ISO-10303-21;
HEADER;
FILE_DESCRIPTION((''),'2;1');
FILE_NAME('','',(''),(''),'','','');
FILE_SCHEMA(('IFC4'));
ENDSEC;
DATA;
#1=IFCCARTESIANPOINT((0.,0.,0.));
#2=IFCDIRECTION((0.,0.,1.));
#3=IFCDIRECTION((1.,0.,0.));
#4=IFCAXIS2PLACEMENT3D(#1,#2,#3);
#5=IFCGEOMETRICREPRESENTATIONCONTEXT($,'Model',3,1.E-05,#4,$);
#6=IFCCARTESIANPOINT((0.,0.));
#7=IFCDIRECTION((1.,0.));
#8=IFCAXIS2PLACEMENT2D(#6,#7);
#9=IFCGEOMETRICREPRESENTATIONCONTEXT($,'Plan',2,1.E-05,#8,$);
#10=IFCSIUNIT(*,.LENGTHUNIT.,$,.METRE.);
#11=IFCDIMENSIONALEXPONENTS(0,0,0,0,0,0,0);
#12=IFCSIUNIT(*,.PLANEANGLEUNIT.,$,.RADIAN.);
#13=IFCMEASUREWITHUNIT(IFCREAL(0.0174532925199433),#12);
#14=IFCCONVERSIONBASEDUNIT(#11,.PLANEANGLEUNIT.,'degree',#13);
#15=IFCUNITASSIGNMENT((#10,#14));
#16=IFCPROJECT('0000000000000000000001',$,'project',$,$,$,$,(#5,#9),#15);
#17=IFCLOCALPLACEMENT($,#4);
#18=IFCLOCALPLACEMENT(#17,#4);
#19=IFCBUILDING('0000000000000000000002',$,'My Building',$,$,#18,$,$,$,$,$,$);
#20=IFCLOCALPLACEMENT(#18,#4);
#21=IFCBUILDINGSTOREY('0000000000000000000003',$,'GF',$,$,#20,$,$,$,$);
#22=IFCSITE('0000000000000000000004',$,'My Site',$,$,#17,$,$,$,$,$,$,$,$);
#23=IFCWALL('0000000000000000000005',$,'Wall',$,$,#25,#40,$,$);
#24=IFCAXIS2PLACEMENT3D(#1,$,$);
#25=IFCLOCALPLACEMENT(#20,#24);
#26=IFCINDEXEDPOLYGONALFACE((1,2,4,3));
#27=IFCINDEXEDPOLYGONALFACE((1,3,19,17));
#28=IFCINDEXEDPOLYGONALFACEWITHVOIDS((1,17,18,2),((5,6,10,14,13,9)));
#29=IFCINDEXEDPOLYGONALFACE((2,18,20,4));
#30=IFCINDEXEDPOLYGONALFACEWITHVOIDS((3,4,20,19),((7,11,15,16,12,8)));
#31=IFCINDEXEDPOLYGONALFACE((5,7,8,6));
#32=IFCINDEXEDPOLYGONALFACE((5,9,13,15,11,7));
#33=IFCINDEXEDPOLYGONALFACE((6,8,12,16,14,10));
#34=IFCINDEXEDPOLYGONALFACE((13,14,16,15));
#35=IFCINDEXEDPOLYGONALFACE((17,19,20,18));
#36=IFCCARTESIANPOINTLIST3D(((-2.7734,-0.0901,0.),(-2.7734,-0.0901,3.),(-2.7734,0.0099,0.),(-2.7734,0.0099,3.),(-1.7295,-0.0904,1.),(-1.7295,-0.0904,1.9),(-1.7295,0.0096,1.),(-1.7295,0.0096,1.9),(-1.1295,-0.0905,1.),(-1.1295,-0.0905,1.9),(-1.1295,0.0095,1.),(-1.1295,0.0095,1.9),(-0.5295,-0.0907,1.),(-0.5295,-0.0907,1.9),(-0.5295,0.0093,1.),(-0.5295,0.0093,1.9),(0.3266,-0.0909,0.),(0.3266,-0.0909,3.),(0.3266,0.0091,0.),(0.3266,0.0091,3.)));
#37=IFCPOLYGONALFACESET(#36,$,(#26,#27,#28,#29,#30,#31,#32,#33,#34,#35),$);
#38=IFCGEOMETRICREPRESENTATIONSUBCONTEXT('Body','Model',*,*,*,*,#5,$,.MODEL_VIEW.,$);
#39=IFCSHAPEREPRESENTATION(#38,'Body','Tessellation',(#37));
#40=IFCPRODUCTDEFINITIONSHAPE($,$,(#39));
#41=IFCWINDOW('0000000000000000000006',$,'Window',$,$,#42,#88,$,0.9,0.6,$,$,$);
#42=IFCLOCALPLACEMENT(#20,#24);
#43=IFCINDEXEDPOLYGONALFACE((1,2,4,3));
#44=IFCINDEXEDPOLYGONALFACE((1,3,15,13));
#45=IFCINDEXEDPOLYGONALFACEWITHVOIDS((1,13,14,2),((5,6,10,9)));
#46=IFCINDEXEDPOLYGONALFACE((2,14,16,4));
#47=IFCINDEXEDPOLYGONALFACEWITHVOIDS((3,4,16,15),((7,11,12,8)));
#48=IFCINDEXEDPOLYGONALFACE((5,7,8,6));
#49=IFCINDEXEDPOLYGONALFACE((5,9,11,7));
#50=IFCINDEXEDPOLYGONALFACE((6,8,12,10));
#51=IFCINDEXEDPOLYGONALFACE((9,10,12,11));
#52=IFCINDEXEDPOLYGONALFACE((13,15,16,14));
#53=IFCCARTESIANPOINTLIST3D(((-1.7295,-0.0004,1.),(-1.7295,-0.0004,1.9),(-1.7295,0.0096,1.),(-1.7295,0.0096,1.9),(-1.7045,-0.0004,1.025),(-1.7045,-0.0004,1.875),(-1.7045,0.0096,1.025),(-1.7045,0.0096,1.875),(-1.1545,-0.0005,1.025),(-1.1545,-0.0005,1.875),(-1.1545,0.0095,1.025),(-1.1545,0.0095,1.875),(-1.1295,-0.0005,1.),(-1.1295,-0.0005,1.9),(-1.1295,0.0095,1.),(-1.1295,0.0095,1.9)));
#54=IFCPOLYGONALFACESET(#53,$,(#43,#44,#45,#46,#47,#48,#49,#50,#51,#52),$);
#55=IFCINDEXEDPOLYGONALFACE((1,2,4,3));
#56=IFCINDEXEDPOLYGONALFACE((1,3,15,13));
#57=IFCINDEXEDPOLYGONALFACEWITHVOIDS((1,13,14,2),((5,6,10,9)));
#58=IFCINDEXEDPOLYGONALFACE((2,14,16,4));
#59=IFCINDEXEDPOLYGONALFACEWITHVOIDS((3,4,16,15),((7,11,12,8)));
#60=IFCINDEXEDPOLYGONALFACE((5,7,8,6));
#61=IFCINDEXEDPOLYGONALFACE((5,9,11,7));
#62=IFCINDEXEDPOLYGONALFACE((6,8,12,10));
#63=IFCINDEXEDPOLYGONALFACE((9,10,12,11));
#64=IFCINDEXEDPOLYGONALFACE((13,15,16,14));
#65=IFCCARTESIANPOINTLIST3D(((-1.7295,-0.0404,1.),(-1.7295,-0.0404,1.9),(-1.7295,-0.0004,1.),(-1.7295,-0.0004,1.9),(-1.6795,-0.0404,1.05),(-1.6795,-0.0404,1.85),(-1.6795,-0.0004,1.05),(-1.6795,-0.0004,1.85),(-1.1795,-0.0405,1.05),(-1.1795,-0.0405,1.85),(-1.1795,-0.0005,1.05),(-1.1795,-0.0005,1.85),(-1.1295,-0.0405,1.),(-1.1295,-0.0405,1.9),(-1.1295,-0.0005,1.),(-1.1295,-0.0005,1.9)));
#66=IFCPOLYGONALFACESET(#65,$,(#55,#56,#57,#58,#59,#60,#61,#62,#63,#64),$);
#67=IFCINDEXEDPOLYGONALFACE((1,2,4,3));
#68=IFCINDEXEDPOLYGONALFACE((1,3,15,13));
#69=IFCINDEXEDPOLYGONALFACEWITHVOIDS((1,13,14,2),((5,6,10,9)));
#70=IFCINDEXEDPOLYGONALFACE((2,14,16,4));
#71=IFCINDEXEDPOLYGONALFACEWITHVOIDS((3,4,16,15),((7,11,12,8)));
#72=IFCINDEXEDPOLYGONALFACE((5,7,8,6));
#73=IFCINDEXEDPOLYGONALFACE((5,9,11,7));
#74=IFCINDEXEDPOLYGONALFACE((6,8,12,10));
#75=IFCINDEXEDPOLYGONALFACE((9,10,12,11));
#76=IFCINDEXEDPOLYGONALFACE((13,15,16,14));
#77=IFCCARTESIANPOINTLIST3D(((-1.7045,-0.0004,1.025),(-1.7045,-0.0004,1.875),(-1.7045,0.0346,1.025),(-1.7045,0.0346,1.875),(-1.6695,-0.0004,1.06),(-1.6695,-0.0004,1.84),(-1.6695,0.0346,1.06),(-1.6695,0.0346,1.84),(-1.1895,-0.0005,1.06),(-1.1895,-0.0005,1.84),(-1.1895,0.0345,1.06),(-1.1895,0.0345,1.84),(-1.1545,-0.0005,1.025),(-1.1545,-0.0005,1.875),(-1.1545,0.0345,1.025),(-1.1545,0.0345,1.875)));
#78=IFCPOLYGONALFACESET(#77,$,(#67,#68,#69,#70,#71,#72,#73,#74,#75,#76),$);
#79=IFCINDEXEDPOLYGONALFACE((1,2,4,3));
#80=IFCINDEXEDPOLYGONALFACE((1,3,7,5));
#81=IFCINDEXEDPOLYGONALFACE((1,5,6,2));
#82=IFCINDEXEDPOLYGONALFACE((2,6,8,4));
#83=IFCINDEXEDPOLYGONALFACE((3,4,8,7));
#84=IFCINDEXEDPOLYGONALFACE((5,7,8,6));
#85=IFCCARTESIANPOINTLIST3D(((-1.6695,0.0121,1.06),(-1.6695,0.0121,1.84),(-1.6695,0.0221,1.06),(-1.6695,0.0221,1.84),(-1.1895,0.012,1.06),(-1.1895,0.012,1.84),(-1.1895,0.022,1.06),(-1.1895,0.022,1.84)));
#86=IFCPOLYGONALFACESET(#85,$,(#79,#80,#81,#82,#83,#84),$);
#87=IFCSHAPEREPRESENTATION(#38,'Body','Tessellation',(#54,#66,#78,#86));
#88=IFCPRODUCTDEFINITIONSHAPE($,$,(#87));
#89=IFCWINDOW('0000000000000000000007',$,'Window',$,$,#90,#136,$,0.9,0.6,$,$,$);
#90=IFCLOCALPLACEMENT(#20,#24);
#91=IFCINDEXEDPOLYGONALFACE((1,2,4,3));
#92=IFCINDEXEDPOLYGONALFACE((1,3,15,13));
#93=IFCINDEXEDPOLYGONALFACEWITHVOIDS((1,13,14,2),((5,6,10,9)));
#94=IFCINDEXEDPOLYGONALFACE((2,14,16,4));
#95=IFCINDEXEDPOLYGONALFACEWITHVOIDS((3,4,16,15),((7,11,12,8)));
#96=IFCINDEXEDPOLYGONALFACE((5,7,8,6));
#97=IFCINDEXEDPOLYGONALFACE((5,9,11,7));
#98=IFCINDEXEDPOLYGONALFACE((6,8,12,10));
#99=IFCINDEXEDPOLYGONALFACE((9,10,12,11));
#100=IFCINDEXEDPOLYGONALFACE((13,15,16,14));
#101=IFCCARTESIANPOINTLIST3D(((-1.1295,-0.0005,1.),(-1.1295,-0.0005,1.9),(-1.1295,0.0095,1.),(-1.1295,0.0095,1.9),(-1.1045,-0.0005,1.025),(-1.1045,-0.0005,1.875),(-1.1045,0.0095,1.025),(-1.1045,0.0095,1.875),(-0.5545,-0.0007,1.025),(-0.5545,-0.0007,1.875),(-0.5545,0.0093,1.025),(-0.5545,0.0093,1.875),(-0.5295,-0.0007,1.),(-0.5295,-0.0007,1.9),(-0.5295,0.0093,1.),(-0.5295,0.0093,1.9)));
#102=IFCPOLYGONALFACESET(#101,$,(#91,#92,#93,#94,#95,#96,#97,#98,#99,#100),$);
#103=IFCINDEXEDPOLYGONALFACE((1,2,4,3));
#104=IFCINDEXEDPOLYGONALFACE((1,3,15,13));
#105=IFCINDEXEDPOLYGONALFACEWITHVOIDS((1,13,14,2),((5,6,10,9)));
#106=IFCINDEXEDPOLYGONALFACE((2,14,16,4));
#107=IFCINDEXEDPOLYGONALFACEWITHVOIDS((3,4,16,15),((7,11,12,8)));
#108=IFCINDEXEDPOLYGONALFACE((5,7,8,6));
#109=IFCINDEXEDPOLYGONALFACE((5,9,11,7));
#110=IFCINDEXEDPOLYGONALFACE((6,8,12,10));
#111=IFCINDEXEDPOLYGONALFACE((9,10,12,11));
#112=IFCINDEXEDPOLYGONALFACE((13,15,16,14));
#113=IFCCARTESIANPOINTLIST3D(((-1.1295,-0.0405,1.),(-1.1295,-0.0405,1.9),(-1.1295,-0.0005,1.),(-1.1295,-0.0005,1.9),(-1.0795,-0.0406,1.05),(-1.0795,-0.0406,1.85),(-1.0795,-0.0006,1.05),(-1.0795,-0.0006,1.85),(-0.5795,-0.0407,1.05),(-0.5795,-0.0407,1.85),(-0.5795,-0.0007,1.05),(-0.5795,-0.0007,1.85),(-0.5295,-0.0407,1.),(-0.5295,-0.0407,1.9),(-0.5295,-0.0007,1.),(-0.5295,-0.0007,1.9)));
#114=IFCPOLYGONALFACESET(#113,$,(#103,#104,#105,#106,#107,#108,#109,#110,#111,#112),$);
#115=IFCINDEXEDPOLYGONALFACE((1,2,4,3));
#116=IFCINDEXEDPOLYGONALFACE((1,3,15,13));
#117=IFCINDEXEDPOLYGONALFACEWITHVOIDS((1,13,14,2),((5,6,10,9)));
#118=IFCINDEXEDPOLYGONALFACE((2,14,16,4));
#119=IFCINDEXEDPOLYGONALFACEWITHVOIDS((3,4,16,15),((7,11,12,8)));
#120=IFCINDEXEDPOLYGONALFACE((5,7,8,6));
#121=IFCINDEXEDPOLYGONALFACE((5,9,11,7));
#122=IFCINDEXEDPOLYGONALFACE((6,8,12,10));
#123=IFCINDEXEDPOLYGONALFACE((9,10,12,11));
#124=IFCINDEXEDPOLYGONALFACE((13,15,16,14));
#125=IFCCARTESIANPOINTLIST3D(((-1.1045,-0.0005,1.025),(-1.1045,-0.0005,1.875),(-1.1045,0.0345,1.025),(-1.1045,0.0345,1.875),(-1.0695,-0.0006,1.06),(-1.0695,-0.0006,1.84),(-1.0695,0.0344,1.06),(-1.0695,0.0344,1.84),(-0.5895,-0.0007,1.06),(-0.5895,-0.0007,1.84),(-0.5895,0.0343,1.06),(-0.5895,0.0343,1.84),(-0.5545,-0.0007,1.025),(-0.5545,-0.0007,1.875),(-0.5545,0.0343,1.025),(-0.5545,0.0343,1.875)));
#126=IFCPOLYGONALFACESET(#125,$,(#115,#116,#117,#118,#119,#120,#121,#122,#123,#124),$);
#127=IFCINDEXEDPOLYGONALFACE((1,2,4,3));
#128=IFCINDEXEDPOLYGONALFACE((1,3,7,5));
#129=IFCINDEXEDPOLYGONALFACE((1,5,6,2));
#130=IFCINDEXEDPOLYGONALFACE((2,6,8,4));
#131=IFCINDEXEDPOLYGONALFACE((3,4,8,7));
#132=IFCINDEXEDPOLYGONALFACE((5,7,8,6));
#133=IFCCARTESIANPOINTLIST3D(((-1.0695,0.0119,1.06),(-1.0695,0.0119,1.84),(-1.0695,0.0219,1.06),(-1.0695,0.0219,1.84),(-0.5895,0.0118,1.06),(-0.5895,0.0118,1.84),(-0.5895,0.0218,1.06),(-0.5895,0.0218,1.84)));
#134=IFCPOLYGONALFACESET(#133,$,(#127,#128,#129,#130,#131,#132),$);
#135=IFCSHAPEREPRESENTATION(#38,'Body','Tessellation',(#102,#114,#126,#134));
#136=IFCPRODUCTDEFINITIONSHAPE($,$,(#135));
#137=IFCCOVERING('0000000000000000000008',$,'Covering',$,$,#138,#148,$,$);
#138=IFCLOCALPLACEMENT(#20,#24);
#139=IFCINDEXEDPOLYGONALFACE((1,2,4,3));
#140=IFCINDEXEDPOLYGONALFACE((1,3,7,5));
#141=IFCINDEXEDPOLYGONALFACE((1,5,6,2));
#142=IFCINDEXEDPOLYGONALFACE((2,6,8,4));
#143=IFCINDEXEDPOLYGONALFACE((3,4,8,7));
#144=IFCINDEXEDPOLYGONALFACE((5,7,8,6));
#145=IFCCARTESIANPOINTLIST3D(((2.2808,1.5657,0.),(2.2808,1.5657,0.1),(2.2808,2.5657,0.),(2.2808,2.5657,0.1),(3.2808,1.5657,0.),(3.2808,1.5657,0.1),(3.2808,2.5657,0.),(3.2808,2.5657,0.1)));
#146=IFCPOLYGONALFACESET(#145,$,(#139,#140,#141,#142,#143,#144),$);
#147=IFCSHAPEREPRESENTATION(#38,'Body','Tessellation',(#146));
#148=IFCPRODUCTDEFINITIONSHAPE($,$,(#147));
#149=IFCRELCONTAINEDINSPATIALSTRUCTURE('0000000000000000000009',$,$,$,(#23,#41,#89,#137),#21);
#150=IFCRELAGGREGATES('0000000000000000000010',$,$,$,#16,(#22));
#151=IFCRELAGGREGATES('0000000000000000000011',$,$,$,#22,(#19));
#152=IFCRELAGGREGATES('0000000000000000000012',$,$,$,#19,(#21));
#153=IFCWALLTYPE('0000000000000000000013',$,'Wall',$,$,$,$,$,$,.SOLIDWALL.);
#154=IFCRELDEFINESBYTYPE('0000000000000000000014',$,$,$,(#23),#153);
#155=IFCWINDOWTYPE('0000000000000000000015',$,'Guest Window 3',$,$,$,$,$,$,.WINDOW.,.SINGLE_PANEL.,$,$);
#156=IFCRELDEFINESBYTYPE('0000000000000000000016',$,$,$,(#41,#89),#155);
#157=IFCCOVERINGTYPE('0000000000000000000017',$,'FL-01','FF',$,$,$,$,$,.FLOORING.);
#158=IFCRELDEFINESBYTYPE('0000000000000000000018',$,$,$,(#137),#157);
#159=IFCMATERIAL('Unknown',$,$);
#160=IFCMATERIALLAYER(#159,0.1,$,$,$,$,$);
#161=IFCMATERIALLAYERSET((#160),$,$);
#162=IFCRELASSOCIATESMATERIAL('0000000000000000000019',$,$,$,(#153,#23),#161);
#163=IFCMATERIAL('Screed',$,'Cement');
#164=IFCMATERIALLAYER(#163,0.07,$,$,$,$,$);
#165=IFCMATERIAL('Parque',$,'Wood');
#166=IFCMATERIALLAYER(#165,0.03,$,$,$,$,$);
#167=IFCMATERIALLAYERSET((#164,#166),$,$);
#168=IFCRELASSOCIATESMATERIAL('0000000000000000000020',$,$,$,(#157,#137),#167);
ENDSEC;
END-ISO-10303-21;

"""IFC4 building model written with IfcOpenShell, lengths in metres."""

from ifc_helpers import new_model, entity, si_unit, converted_unit, frame, origin_with_axes, origin_2d_with_axis, place, context, subcontext, project, spatial, line, indexed_curve, outline, extrude, shape, source, transform, mapped, material, layer, layer_set, layer_usage, type_object, type_shapes, element, fill, save


model = new_model("IFC4")

# Units and contexts
model_context = context("Model", 3, precision=1e-05, world=origin_with_axes())
plan_context = context("Plan", 2, precision=1e-05, world=origin_2d_with_axis())
body_context_1 = subcontext(model_context, "Body", "Model", "MODEL_VIEW")
body_context_2 = subcontext(plan_context, "Body", "Plan", "PLAN_VIEW")
ifc_project = project(units=[si_unit("LENGTHUNIT", "METRE"), converted_unit("PLANEANGLEUNIT", "degree", entity("IfcReal", 0.0174532925199433), si_unit("PLANEANGLEUNIT", "RADIAN"), dimensions=[0, 0, 0, 0, 0, 0, 0])], contexts=[model_context, plan_context])

# Site, building, storey
site_placement = place(None, origin_with_axes())
site = spatial("IfcSite", under=ifc_project, at=site_placement, Name="My Site")
building_placement = place(site_placement, origin_with_axes())
building = spatial("IfcBuilding", under=site, at=building_placement, Name="My Building")
storey_placement = place(building_placement, origin_with_axes())
storey = spatial("IfcBuildingStorey", under=building, at=storey_placement, Name="GF")

# Shared definitions
ifc_material_1 = material(Name="Unknown")

# Shared definitions
ifc_layer_1 = layer(ifc_material_1, 0.1)
ifc_layer_set_1 = layer_set([ifc_layer_1])
wall_type = type_object("IfcWallType", Name="Wall", PredefinedType="SOLIDWALL", material=ifc_layer_set_1)

# Wall, openings, windows
ifc_layer_usage_1 = layer_usage(ifc_layer_set_1, "AXIS2", "POSITIVE", 0.0)
wall_1_placement = place(storey_placement, frame((-2.7734, -0.0901, 0.0), z_axis=(0.0, 0.0, 1.0), x_axis=(1.0, -0.000264, 0.0)))
wall_1 = element("IfcWall", 1, at=wall_1_placement, inside=storey, type_object=wall_type, material=ifc_layer_usage_1, Name="Wall", context=body_context_1, shape_type="SweptSolid", body=[
    extrude(outline(indexed_curve([(0.0, 0.0), (0.0, 0.1), (3.1, 0.1), (3.1, 0.0)], segments=[line(1, 2, 3, 4, 1)])), origin_with_axes(), (0.0, 0.0, 1.0), 3.0),
])
shared_shape_1 = source(origin_with_axes(), body_context_1, "Body", "SweptSolid", [
    extrude(outline(indexed_curve([(0.0, 0.0), (0.6, 0.0), (0.6, 0.9), (0.0, 0.9)], segments=[line(1, 2, 3, 4, 1)])), frame((0.0, -0.6, 0.0), z_axis=(0.0, -1.0, 0.0), x_axis=(1.0, 0.0, 0.0)), (0.0, 0.0, -1.0), 1.2),
])
opening_1_placement = place(wall_1_placement, frame((1.0439, 0.0, 1.0), z_axis=(0.0, 0.0, 1.0), x_axis=(1.0, 0.0, 0.0)))
opening_1 = element("IfcOpeningElement", 2, at=opening_1_placement, cuts=wall_1, PredefinedType="OPENING", context=body_context_1, shape_type="MappedRepresentation", body=[
    mapped(shared_shape_1, transform((0.0, 0.0, 0.0), x_axis=(1.0, 0.0, 0.0), y_axis=(0.0, 1.0, 0.0), z_axis=(0.0, 0.0, 1.0), scale=1.0)),
])
opening_2_placement = place(wall_1_placement, frame((1.6439, 0.0, 1.0), z_axis=(0.0, 0.0, 1.0), x_axis=(1.0, 0.0, 0.0)))
opening_2 = element("IfcOpeningElement", 3, at=opening_2_placement, cuts=wall_1, PredefinedType="OPENING", context=body_context_1, shape_type="MappedRepresentation", body=[
    mapped(shared_shape_1, transform((0.0, 0.0, 0.0), x_axis=(1.0, 0.0, 0.0), y_axis=(0.0, 1.0, 0.0), z_axis=(0.0, 0.0, 1.0), scale=1.0)),
])
window_type_1 = type_object("IfcWindowType", Name="Guest Window 3", PartitioningType="SINGLE_PANEL", PredefinedType="WINDOW")
shared_shape_2 = source(origin_with_axes(), body_context_1, "Body", "SweptSolid", [
    extrude(outline(indexed_curve([(0.0, 0.0), (0.6, 0.0), (0.6, 0.9), (0.0, 0.9)], segments=[line(1, 2, 3, 4, 1)]), holes=[indexed_curve([(0.025, 0.025), (0.575, 0.025), (0.575, 0.875), (0.025, 0.875)], segments=[line(1, 2, 3, 4, 1)])]), frame((0.0, 0.09, 0.0), z_axis=(0.0, -1.0, 0.0), x_axis=(1.0, 0.0, 0.0)), (0.0, 0.0, -1.0), 0.01),
    extrude(outline(indexed_curve([(0.0, 0.0), (0.6, 0.0), (0.6, 0.9), (0.0, 0.9)], segments=[line(1, 2, 3, 4, 1)]), holes=[indexed_curve([(0.05, 0.05), (0.55, 0.05), (0.55, 0.85), (0.05, 0.85)], segments=[line(1, 2, 3, 4, 1)])]), frame((0.0, 0.05, 0.0), z_axis=(0.0, -1.0, 0.0), x_axis=(1.0, 0.0, 0.0)), (0.0, 0.0, -1.0), 0.04),
    extrude(outline(indexed_curve([(0.0, 0.0), (0.55, 0.0), (0.55, 0.85), (0.0, 0.85)], segments=[line(1, 2, 3, 4, 1)]), holes=[indexed_curve([(0.035, 0.035), (0.515, 0.035), (0.515, 0.815), (0.035, 0.815)], segments=[line(1, 2, 3, 4, 1)])]), frame((0.025, 0.09, 0.025), z_axis=(0.0, -1.0, 0.0), x_axis=(1.0, 0.0, 0.0)), (0.0, 0.0, -1.0), 0.035),
    extrude(outline(indexed_curve([(0.035, 0.035), (0.515, 0.035), (0.515, 0.815), (0.035, 0.815)], segments=[line(1, 2, 3, 4, 1)])), frame((0.025, 0.1025, 0.025), z_axis=(0.0, -1.0, 0.0), x_axis=(1.0, 0.0, 0.0)), (0.0, 0.0, -1.0), 0.01),
])
shared_shape_3 = source(origin_with_axes(), body_context_2, "Body", "Curve2D", [
    entity("IfcIndexedPolyCurve", entity("IfcCartesianPointList2D", [[0.05, 0.05], [0.55, 0.05]])),
    entity("IfcIndexedPolyCurve", entity("IfcCartesianPointList2D", [[0.0, 0.1], [0.025, 0.1], [0.025, 0.09], [0.05, 0.09], [0.05, 0.05], [0.0, 0.05]]), [entity("IfcLineIndex", [1, 2, 3, 4, 5, 6, 1])]),
    entity("IfcIndexedPolyCurve", entity("IfcCartesianPointList2D", [[0.6, 0.1], [0.575, 0.1], [0.575, 0.09], [0.55, 0.09], [0.55, 0.05], [0.6, 0.05]]), [entity("IfcLineIndex", [1, 2, 3, 4, 5, 6, 1])]),
    entity("IfcIndexedPolyCurve", entity("IfcCartesianPointList2D", [[0.025, 0.09], [0.06, 0.09], [0.06, 0.125], [0.025, 0.125]]), [entity("IfcLineIndex", [1, 2, 3, 4, 1])]),
    entity("IfcIndexedPolyCurve", entity("IfcCartesianPointList2D", [[0.575, 0.09], [0.54, 0.09], [0.54, 0.125], [0.575, 0.125]]), [entity("IfcLineIndex", [1, 2, 3, 4, 1])]),
    entity("IfcIndexedPolyCurve", entity("IfcCartesianPointList2D", [[0.06, 0.09], [0.54, 0.09]])),
    entity("IfcIndexedPolyCurve", entity("IfcCartesianPointList2D", [[0.06, 0.125], [0.54, 0.125]])),
    entity("IfcIndexedPolyCurve", entity("IfcCartesianPointList2D", [[0.06, 0.1075], [0.54, 0.1075]])),
])
type_shapes(window_type_1, [shared_shape_2, shared_shape_3])
window_1_placement = place(opening_1_placement, frame((0.0, 0.0, 0.0), z_axis=(0.0, 0.0, 1.0), x_axis=(1.0, 0.0, 0.0)))
window_1 = element("IfcWindow", 4, at=window_1_placement, inside=storey, type_object=window_type_1, Name="Window", OverallHeight=0.9, OverallWidth=0.6, shapes=[
    shape(body_context_1, "Body", "MappedRepresentation", [mapped(shared_shape_2, transform((0.0, 0.0, 0.0), x_axis=(1.0, 0.0, 0.0), y_axis=(0.0, 1.0, 0.0), z_axis=(0.0, 0.0, 1.0), scale=1.0))]),
    shape(body_context_2, "Body", "MappedRepresentation", [mapped(shared_shape_3, transform((0.0, 0.0, 0.0), x_axis=(1.0, 0.0, 0.0), y_axis=(0.0, 1.0, 0.0), z_axis=(0.0, 0.0, 1.0), scale=1.0))]),
])
fill(opening_1, window_1)
window_2_placement = place(opening_2_placement, frame((0.0, 0.0, 0.0), z_axis=(0.0, 0.0, 1.0), x_axis=(1.0, 0.0, 0.0)))
window_2 = element("IfcWindow", 5, at=window_2_placement, inside=storey, type_object=window_type_1, Name="Window", OverallHeight=0.9, OverallWidth=0.6, shapes=[
    shape(body_context_1, "Body", "MappedRepresentation", [mapped(shared_shape_2, transform((0.0, 0.0, 0.0), x_axis=(1.0, 0.0, 0.0), y_axis=(0.0, 1.0, 0.0), z_axis=(0.0, 0.0, 1.0), scale=1.0))]),
    shape(body_context_2, "Body", "MappedRepresentation", [mapped(shared_shape_3, transform((0.0, 0.0, 0.0), x_axis=(1.0, 0.0, 0.0), y_axis=(0.0, 1.0, 0.0), z_axis=(0.0, 0.0, 1.0), scale=1.0))]),
])
fill(opening_2, window_2)

# Covering
ifc_material_2 = material(Name="Screed", Category="Cement")
ifc_layer_2 = layer(ifc_material_2, 0.07)
ifc_material_3 = material(Name="Parque", Category="Wood")
ifc_layer_3 = layer(ifc_material_3, 0.03)
ifc_layer_set_2 = layer_set([ifc_layer_2, ifc_layer_3])
ifc_layer_usage_2 = layer_usage(ifc_layer_set_2, "AXIS3", "POSITIVE", 0.0)
covering_type = type_object("IfcCoveringType", Name="FL-01", Description="FF", PredefinedType="FLOORING", material=ifc_layer_set_2)
covering_placement = place(storey_placement, frame((2.2808, 1.5657, 0.0), z_axis=(0.0, 0.0, 1.0), x_axis=(1.0, 0.0, 0.0)))
element("IfcCovering", 6, at=covering_placement, inside=storey, type_object=covering_type, material=ifc_layer_usage_2, Name="Covering", context=body_context_1, shape_type="SweptSolid", body=[
    extrude(outline(indexed_curve([(0.0, 0.0), (1.0, 0.0), (1.0, 1.0), (0.0, 1.0), (0.0, 0.0)])), None, (0.0, 0.0, 1.0), 0.1),
])

save(model, "model.ifc")
